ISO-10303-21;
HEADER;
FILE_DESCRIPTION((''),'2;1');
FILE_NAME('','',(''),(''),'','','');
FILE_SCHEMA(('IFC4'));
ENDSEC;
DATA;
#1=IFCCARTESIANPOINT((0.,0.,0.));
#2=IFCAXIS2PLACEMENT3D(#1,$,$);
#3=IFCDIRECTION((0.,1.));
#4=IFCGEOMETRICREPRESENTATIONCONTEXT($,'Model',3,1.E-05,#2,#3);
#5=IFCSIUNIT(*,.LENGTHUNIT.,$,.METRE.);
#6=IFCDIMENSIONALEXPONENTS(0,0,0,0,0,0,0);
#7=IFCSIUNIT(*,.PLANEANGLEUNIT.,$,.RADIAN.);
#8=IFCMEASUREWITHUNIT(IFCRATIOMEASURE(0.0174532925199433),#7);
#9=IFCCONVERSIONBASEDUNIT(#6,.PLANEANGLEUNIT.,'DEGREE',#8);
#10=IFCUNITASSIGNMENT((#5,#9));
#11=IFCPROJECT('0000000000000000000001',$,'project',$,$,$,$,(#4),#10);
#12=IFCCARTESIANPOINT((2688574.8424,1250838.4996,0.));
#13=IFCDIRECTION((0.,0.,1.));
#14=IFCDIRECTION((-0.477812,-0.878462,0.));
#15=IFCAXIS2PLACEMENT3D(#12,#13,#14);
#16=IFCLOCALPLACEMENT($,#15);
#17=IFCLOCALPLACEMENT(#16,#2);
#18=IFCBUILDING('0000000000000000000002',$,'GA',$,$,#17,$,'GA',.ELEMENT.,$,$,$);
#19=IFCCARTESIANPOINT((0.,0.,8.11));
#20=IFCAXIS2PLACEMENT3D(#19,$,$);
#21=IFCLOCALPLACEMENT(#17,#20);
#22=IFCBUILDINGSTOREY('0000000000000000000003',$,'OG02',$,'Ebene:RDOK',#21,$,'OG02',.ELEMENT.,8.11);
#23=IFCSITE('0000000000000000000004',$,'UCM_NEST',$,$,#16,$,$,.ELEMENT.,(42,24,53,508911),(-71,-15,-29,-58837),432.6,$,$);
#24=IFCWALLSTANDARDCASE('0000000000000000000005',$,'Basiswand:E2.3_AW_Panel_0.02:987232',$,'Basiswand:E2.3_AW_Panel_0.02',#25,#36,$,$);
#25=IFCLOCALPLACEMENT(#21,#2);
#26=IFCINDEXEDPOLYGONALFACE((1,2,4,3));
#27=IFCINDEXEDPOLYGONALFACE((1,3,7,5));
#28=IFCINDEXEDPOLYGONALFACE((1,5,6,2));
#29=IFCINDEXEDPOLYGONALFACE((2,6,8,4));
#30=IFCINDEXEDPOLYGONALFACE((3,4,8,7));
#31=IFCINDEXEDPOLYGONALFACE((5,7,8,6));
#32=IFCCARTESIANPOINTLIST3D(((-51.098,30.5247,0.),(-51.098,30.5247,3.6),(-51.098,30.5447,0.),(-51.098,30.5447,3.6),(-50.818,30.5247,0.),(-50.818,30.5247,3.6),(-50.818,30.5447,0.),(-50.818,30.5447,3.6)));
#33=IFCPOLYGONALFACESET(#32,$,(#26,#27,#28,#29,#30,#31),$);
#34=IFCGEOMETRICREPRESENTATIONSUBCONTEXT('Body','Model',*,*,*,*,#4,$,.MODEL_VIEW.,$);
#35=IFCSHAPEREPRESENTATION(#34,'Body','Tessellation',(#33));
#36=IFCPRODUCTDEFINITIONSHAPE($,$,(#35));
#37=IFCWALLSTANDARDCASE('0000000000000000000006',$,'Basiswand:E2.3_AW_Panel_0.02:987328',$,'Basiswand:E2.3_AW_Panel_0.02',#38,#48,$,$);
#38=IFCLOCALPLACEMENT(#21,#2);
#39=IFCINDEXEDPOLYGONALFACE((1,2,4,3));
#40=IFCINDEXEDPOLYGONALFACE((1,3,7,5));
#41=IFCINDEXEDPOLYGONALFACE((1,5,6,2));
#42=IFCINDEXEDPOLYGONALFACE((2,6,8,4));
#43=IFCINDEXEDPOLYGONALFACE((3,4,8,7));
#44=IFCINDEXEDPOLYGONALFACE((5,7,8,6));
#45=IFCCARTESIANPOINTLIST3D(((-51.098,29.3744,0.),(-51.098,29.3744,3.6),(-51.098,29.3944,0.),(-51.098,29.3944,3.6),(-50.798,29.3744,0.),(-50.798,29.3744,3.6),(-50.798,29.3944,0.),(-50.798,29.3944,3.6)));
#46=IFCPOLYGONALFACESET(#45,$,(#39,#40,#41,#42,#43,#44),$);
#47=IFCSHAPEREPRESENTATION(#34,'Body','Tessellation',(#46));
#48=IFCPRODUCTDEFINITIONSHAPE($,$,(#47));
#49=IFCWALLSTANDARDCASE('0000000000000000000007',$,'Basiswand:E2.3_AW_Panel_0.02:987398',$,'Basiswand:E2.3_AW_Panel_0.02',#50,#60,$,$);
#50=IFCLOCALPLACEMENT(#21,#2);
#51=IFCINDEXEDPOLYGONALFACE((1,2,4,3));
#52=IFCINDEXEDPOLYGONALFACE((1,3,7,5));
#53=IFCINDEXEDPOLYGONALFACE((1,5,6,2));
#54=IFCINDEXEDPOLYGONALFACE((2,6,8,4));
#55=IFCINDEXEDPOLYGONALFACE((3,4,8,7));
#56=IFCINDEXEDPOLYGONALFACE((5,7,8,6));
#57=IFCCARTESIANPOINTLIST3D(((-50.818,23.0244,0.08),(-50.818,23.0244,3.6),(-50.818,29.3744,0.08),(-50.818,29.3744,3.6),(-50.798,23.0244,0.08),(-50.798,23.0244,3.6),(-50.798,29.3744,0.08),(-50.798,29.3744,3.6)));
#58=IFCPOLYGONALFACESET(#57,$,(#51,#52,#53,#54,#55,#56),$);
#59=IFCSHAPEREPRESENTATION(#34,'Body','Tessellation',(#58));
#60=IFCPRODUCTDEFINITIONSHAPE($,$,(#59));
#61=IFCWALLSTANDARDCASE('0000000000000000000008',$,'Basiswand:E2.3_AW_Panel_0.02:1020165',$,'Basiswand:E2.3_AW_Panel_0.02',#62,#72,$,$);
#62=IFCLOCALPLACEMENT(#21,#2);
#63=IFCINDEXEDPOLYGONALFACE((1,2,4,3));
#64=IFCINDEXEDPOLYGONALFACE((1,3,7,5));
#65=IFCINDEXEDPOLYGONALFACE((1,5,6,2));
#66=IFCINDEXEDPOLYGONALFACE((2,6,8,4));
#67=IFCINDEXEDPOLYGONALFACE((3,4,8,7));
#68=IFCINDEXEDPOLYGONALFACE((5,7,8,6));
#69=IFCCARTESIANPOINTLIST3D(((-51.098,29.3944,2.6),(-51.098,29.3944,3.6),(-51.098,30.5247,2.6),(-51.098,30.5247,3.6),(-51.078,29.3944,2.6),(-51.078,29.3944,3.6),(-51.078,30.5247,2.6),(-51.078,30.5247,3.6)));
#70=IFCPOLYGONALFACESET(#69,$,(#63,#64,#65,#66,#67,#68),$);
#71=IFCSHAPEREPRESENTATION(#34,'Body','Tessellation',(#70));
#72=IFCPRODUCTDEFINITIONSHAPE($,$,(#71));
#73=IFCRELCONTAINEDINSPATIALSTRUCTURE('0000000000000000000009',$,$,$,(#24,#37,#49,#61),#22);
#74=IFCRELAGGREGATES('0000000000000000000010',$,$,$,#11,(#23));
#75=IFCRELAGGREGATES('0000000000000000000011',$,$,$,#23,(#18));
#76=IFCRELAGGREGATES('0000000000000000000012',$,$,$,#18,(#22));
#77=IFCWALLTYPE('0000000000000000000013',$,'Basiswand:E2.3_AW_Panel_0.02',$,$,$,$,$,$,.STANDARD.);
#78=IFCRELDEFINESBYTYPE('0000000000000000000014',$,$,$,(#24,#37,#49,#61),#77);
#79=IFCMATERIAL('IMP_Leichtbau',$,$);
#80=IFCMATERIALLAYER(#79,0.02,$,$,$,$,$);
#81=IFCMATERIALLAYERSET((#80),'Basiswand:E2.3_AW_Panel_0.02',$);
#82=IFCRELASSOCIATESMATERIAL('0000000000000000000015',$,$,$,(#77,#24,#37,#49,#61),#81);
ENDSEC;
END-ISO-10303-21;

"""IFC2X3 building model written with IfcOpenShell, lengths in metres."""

from ifc_helpers import new_model, entity, si_unit, converted_unit, direction, frame, frame_2d, origin, place, context, subcontext, project, spatial, polyline, rectangle, extrude, clip, bounded_halfspace, material, layer, layer_set, layer_usage, type_object, element, save


model = new_model("IFC2X3")

# Units and contexts
model_context = context("Model", 3, precision=1e-05, world=origin(), true_north=direction((0.0, 1.0)))
body_context = subcontext(model_context, "Body", "Model", "MODEL_VIEW")
ifc_project = project(units=[si_unit("LENGTHUNIT", "METRE"), converted_unit("PLANEANGLEUNIT", "DEGREE", entity("IfcRatioMeasure", 0.0174532925199433), si_unit("PLANEANGLEUNIT", "RADIAN"), dimensions=[0, 0, 0, 0, 0, 0, 0])], contexts=[model_context])

# Site, building, storey
site_placement = place(None, frame((2688574.8424, 1250838.4996, 0.0), z_axis=(0.0, 0.0, 1.0), x_axis=(-0.477812, -0.878462, 0.0)))
site = spatial("IfcSite", under=ifc_project, at=site_placement, Name="UCM_NEST", CompositionType="ELEMENT", RefLatitude=(42, 24, 53, 508911), RefLongitude=(-71, -15, -29, -58837), RefElevation=432.6)
building_placement = place(site_placement, origin())
building = spatial("IfcBuilding", under=site, at=building_placement, Name="GA", LongName="GA", CompositionType="ELEMENT")
storey_placement = place(building_placement, frame((0.0, 0.0, 8.11)))
storey = spatial("IfcBuildingStorey", under=building, at=storey_placement, Name="OG02", ObjectType="Ebene:RDOK", LongName="OG02", CompositionType="ELEMENT", Elevation=8.11)

# Shared definitions
ifc_material_1 = material(Name="IMP_Leichtbau")

# Walls
ifc_layer_1 = layer(ifc_material_1, 0.02)
ifc_layer_set_1 = layer_set([ifc_layer_1], Name="Basiswand:E2.3_AW_Panel_0.02")
wall_type_1 = type_object("IfcWallType", Name="Basiswand:E2.3_AW_Panel_0.02", PredefinedType="STANDARD", material=ifc_layer_set_1)
ifc_layer_usage_1 = layer_usage(ifc_layer_set_1, "AXIS2", "NEGATIVE", 0.01)
wall_1_placement = place(storey_placement, frame((-50.818, 30.5347, 0.0), z_axis=(0.0, 0.0, 1.0), x_axis=(-1.0, 0.0, 0.0)))
element("IfcWallStandardCase", 1, at=wall_1_placement, inside=storey, type_object=wall_type_1, material=ifc_layer_usage_1, Name="Basiswand:E2.3_AW_Panel_0.02:987232", ObjectType="Basiswand:E2.3_AW_Panel_0.02", context=body_context, shape_type="SweptSolid", body=[
    extrude(rectangle(XDim=0.28, YDim=0.02, at=frame_2d((0.14, 0.0), x_axis=(-1.0, 0.0))), origin(), (0.0, 0.0, 1.0), 3.6),
])
ifc_layer_usage_2 = layer_usage(ifc_layer_set_1, "AXIS2", "NEGATIVE", 0.01)
wall_2_placement = place(storey_placement, frame((-51.098, 29.3844, 0.0)))
element("IfcWallStandardCase", 2, at=wall_2_placement, inside=storey, type_object=wall_type_1, material=ifc_layer_usage_2, Name="Basiswand:E2.3_AW_Panel_0.02:987328", ObjectType="Basiswand:E2.3_AW_Panel_0.02", context=body_context, shape_type="SweptSolid", body=[
    extrude(rectangle(XDim=0.3, YDim=0.02, at=frame_2d((0.15, 0.0), x_axis=(-1.0, 0.0))), origin(), (0.0, 0.0, 1.0), 3.6),
])
ifc_layer_usage_3 = layer_usage(ifc_layer_set_1, "AXIS2", "NEGATIVE", 0.01)
wall_3_placement = place(storey_placement, frame((-50.808, 29.3744, 0.08), z_axis=(0.0, 0.0, 1.0), x_axis=(0.0, -1.0, 0.0)))
element("IfcWallStandardCase", 3, at=wall_3_placement, inside=storey, type_object=wall_type_1, material=ifc_layer_usage_3, Name="Basiswand:E2.3_AW_Panel_0.02:987398", ObjectType="Basiswand:E2.3_AW_Panel_0.02", context=body_context, shape_type="Clipping", body=[
    clip(extrude(rectangle(XDim=6.35, YDim=0.02, at=frame_2d((3.175, 0.0), x_axis=(-1.0, 0.0))), origin(), (0.0, 0.0, 1.0), 3.52), bounded_halfspace(frame((6.35, -0.01, 0.0), z_axis=(0.0, 0.0, 1.0), x_axis=(0.0, -1.0, 0.0)), True, frame((6.35, -0.01, 0.0), z_axis=(0.0, 0.0, 1.0), x_axis=(0.0, -1.0, 0.0)), polyline([(0.0, 0.0), (-0.02, 0.0), (-0.02, -6.35), (0.0, -6.35), (0.0, 0.0)]))),
])
ifc_layer_usage_4 = layer_usage(ifc_layer_set_1, "AXIS2", "NEGATIVE", 0.01)
wall_4_placement = place(storey_placement, frame((-51.088, 30.5247, 2.6), z_axis=(0.0, 0.0, 1.0), x_axis=(0.0, -1.0, 0.0)))
element("IfcWallStandardCase", 4, at=wall_4_placement, inside=storey, type_object=wall_type_1, material=ifc_layer_usage_4, Name="Basiswand:E2.3_AW_Panel_0.02:1020165", ObjectType="Basiswand:E2.3_AW_Panel_0.02", context=body_context, shape_type="SweptSolid", body=[
    extrude(rectangle(XDim=1.1302, YDim=0.02, at=frame_2d((0.5651, 0.0), x_axis=(-1.0, 0.0))), origin(), (0.0, 0.0, 1.0), 1.0),
])

save(model, "model.ifc")
